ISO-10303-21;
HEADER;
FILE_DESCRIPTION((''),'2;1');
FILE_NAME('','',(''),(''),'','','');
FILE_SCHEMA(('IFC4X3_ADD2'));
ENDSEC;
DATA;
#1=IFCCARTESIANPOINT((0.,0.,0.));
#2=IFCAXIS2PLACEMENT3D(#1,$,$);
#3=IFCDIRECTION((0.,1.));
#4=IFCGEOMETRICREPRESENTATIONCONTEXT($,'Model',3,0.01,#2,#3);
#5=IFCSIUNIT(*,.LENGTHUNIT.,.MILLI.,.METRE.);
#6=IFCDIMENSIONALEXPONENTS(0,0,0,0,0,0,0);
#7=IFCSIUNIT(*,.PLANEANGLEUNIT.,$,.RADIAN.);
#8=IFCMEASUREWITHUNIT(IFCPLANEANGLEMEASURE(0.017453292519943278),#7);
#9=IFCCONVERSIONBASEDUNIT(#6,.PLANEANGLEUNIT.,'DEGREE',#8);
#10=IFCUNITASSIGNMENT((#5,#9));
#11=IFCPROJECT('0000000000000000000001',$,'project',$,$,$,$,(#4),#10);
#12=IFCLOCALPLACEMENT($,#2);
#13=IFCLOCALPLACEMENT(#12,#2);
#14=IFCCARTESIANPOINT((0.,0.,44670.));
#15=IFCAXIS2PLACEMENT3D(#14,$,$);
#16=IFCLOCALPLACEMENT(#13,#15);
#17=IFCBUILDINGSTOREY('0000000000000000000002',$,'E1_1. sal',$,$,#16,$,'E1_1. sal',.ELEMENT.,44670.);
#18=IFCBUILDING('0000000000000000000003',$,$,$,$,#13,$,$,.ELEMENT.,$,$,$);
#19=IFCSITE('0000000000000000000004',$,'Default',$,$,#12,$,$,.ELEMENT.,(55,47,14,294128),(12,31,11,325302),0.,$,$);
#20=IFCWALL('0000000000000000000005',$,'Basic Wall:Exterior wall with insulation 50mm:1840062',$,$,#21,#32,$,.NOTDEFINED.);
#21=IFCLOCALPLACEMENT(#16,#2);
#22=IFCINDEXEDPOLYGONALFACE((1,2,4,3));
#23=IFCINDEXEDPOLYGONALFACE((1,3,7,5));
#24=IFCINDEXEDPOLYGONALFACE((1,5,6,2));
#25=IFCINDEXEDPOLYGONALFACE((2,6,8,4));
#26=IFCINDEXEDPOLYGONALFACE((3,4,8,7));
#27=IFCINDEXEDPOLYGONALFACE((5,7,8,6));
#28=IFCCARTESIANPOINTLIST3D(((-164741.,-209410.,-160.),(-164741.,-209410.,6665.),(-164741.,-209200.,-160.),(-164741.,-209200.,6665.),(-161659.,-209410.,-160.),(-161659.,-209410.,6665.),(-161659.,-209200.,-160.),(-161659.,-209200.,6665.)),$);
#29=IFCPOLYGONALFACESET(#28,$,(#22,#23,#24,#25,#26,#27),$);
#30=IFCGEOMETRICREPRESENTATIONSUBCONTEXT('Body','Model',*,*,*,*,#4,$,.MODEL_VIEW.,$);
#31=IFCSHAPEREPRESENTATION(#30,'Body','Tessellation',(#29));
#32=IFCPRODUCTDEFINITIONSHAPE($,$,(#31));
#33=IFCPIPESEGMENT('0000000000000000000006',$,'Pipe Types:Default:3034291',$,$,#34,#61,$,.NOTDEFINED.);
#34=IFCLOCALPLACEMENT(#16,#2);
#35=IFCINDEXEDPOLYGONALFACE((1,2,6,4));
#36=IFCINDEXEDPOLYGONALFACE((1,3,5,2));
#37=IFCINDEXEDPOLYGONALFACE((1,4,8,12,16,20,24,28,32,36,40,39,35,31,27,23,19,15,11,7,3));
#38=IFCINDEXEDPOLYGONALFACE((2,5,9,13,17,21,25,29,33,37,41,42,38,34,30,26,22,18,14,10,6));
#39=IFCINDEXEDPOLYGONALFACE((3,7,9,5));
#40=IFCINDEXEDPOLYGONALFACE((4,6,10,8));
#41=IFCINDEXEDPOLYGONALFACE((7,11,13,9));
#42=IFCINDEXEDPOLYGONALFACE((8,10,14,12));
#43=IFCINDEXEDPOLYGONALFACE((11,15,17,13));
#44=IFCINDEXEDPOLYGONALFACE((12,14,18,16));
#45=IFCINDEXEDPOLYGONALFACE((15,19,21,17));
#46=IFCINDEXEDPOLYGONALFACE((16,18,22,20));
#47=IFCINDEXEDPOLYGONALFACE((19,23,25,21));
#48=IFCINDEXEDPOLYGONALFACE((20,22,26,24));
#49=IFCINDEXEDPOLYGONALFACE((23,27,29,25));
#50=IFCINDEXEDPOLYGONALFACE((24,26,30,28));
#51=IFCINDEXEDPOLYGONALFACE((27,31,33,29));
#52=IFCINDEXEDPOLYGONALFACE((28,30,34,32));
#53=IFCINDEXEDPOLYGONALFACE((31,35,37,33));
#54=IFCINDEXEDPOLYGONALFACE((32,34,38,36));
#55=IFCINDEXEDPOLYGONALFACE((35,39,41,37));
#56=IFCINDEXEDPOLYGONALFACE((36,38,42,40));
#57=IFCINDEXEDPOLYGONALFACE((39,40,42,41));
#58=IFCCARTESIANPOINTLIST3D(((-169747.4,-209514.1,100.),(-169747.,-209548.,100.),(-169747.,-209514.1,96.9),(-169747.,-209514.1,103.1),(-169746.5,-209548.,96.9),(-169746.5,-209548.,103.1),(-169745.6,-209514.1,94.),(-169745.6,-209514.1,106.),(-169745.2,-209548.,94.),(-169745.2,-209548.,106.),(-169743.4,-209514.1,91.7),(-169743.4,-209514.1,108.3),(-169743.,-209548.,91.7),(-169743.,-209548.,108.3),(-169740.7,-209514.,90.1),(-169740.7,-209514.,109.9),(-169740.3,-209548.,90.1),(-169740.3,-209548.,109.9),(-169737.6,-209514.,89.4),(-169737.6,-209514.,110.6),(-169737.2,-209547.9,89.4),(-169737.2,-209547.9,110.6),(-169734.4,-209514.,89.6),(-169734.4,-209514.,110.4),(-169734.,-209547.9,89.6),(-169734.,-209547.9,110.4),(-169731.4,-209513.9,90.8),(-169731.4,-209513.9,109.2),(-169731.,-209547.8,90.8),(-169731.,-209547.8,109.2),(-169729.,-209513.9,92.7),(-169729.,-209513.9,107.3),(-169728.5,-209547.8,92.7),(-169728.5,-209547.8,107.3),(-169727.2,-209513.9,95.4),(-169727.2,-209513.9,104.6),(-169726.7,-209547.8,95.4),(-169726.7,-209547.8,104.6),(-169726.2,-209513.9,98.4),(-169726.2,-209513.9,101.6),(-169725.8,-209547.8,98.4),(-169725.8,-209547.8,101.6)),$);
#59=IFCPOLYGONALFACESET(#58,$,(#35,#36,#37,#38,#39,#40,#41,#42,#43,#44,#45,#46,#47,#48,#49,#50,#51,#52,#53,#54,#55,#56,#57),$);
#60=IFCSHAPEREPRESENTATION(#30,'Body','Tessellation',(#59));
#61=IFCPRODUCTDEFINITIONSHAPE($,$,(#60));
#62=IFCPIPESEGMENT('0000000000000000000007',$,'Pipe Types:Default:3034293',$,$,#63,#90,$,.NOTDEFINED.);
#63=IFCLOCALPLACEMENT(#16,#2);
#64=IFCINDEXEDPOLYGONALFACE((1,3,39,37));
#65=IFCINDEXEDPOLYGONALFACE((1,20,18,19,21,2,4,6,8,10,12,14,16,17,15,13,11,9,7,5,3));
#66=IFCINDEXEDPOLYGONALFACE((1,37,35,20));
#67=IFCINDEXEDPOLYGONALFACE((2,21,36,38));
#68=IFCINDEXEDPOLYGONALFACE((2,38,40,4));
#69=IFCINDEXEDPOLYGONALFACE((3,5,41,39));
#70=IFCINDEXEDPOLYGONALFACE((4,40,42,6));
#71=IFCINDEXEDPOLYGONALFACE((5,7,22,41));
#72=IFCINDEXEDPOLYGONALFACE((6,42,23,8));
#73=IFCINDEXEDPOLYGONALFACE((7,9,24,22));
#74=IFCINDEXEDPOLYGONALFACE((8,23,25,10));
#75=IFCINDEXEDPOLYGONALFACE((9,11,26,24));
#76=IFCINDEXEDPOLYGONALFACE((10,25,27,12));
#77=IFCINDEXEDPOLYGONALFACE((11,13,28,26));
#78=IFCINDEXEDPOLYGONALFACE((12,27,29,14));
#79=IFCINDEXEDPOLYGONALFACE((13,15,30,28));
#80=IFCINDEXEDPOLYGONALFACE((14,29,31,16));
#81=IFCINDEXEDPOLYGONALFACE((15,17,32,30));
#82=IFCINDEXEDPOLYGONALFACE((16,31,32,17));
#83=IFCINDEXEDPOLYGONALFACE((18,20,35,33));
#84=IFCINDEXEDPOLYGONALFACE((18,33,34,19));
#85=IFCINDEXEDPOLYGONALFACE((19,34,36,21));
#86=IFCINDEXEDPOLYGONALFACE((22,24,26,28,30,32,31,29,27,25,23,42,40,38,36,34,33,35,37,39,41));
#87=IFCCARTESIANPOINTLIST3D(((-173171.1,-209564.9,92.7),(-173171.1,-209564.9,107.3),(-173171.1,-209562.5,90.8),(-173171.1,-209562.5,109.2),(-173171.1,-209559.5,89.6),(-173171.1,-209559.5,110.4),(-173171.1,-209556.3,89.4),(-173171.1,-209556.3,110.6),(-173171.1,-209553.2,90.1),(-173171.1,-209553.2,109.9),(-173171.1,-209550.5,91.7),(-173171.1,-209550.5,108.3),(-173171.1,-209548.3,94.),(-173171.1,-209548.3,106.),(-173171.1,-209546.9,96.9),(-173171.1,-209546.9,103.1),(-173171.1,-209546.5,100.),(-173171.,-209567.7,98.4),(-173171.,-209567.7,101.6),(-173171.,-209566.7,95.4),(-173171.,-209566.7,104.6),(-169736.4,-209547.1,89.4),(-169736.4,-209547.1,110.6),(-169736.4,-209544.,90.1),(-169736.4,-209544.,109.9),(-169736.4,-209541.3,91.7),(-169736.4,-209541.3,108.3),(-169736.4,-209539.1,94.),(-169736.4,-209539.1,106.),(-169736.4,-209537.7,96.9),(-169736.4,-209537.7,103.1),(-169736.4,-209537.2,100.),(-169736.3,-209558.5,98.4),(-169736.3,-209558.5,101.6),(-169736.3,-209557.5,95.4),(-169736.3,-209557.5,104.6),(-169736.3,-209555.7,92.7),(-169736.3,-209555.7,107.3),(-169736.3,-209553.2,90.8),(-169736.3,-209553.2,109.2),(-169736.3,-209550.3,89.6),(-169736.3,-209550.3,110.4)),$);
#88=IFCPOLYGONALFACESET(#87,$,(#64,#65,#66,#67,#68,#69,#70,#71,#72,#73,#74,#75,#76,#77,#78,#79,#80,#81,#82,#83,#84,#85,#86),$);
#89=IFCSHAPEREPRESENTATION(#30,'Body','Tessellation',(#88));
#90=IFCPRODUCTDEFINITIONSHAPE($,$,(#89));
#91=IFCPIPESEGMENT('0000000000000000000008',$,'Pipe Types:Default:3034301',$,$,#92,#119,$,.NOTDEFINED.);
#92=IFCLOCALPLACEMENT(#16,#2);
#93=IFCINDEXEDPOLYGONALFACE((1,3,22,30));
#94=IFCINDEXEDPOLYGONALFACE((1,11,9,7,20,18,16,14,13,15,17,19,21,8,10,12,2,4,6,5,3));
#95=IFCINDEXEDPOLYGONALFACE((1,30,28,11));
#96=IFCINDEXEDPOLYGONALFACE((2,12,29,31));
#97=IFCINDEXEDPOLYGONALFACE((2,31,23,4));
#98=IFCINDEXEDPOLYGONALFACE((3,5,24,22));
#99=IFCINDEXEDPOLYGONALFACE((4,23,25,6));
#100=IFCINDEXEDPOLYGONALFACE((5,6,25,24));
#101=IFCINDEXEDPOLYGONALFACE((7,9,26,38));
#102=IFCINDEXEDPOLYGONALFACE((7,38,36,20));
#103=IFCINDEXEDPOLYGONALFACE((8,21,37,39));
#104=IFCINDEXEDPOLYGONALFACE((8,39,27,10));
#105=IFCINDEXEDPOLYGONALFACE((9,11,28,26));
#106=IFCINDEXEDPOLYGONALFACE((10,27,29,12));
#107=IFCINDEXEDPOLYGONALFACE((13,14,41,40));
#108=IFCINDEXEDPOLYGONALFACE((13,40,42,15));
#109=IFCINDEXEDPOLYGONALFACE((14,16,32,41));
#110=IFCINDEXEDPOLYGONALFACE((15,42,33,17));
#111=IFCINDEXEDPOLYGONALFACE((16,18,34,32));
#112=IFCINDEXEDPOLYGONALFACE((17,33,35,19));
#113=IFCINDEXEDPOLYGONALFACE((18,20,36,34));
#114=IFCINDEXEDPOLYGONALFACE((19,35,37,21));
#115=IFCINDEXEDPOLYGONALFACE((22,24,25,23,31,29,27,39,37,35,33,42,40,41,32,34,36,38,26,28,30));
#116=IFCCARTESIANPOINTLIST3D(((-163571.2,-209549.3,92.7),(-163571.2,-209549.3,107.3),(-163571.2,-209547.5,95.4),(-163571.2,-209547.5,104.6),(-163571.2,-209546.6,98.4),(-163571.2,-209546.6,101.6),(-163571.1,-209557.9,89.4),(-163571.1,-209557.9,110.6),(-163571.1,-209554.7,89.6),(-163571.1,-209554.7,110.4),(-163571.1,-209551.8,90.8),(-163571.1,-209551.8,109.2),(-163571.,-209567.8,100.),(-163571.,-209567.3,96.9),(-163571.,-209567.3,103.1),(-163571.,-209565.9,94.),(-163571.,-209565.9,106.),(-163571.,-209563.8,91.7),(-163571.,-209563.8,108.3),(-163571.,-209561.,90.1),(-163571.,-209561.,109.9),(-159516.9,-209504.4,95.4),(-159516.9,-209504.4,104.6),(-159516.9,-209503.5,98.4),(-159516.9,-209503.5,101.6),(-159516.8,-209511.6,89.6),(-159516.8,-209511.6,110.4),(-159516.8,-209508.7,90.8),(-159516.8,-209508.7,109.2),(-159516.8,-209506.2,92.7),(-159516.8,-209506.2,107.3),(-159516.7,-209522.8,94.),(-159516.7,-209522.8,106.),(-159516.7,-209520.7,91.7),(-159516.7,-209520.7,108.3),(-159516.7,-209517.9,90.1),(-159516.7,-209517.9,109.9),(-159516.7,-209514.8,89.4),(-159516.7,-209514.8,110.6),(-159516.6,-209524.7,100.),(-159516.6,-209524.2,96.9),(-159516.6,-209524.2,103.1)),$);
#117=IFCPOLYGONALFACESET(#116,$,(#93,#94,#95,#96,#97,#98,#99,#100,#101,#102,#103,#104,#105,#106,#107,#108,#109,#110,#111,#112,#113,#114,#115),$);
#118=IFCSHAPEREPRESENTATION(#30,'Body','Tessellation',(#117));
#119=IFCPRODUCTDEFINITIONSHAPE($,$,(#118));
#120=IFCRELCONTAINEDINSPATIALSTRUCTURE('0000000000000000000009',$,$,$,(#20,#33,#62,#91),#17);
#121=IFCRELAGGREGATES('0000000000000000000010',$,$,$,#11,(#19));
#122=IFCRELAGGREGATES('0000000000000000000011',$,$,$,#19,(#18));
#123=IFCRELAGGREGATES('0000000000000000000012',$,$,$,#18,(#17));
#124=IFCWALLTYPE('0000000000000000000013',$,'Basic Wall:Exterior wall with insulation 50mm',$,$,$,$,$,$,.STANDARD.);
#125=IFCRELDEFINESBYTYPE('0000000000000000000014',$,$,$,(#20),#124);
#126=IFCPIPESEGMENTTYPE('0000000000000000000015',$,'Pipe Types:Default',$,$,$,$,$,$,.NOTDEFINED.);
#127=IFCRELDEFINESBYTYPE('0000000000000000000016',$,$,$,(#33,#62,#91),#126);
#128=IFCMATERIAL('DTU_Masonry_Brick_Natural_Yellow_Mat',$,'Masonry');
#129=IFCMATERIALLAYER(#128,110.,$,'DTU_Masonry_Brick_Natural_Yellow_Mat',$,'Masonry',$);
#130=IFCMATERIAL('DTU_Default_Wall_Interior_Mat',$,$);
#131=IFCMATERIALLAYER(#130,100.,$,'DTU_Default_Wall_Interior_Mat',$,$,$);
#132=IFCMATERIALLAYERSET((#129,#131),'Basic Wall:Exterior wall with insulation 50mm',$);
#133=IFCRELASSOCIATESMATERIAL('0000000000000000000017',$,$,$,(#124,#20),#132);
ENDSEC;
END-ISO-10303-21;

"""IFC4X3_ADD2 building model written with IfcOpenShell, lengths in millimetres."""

from ifc_helpers import new_model, entity, si_unit, converted_unit, direction, frame, frame_2d, origin, origin_2d_with_axis, place, context, subcontext, project, spatial, rectangle, circle, extrude, material, layer, layer_set, type_object, element, save


model = new_model("IFC4X3_ADD2")

# Units and contexts
model_context = context("Model", 3, precision=0.01, world=origin(), true_north=direction((0.0, 1.0)))
body_context = subcontext(model_context, "Body", "Model", "MODEL_VIEW")
ifc_project = project(units=[si_unit("LENGTHUNIT", "METRE", prefix="MILLI"), converted_unit("PLANEANGLEUNIT", "DEGREE", entity("IfcPlaneAngleMeasure", 0.017453292519943278), si_unit("PLANEANGLEUNIT", "RADIAN"), dimensions=[0, 0, 0, 0, 0, 0, 0])], contexts=[model_context])

# Site, building, storey
site_placement = place(None, origin())
site = spatial("IfcSite", under=ifc_project, at=site_placement, Name="Default", CompositionType="ELEMENT", RefLatitude=(55, 47, 14, 294128), RefLongitude=(12, 31, 11, 325302), RefElevation=0.0)
building_placement = place(site_placement, origin())
building = spatial("IfcBuilding", under=site, at=building_placement, CompositionType="ELEMENT")
storey_placement = place(building_placement, frame((0.0, 0.0, 44670.0)))
storey = spatial("IfcBuildingStorey", under=building, at=storey_placement, Name="E1_1. sal", LongName="E1_1. sal", CompositionType="ELEMENT", Elevation=44670.0)

# Wall
ifc_material_1 = material(Name="DTU_Masonry_Brick_Natural_Yellow_Mat", Category="Masonry")
ifc_layer_1 = layer(ifc_material_1, 110.0, Name="DTU_Masonry_Brick_Natural_Yellow_Mat", Category="Masonry")
ifc_material_2 = material(Name="DTU_Default_Wall_Interior_Mat")
ifc_layer_2 = layer(ifc_material_2, 100.0, Name="DTU_Default_Wall_Interior_Mat")
ifc_layer_set = layer_set([ifc_layer_1, ifc_layer_2], Name="Basic Wall:Exterior wall with insulation 50mm")
wall_type = type_object("IfcWallType", Name="Basic Wall:Exterior wall with insulation 50mm", PredefinedType="STANDARD", material=ifc_layer_set)
wall_placement = place(storey_placement, frame((-164741.0, -209305.0, -160.0)))
element("IfcWall", 1, at=wall_placement, inside=storey, type_object=wall_type, material=ifc_layer_set, Name="Basic Wall:Exterior wall with insulation 50mm:1840062", PredefinedType="NOTDEFINED", context=body_context, shape_type="SweptSolid", body=[
    extrude(rectangle(XDim=3082.0, YDim=210.0, at=frame_2d((1541.0, 0.0), x_axis=(-1.0, 0.0))), origin(), (0.0, 0.0, 1.0), 6825.0),
])

# Pipe segments
pipe_segment_type = type_object("IfcPipeSegmentType", Name="Pipe Types:Default", PredefinedType="NOTDEFINED")
pipe_segment_1_placement = place(storey_placement, frame((-169749.0, -209548.0, 87.7)))
element("IfcPipeSegment", 2, at=pipe_segment_1_placement, inside=storey, type_object=pipe_segment_type, Name="Pipe Types:Default:3034291", PredefinedType="NOTDEFINED", context=body_context, shape_type="SweptSolid", body=[
    extrude(circle(Radius=10.7, at=frame_2d((0.0, 0.0), x_axis=(1.0, 0.0))), frame((12.7, 0.1, 12.3), z_axis=(-0.012555, 0.999921, 0.0), x_axis=(-0.999921, -0.012555, 0.0)), (0.0, 0.0, 1.0), 33.9),
])
pipe_segment_2_placement = place(storey_placement, frame((-173171.1, -209569.4, 87.7)))
element("IfcPipeSegment", 3, at=pipe_segment_2_placement, inside=storey, type_object=pipe_segment_type, Name="Pipe Types:Default:3034293", PredefinedType="NOTDEFINED", context=body_context, shape_type="SweptSolid", body=[
    extrude(circle(Radius=10.7, at=frame_2d((0.0, 0.0), x_axis=(1.0, 0.0))), frame((0.0, 12.3, 12.3), z_axis=(0.999996, 0.002683, 0.0), x_axis=(-0.002683, 0.999996, 0.0)), (0.0, 0.0, 1.0), 3434.7),
])
pipe_segment_3_placement = place(storey_placement, frame((-163571.2, -209569.4, 87.7)))
element("IfcPipeSegment", 4, at=pipe_segment_3_placement, inside=storey, type_object=pipe_segment_type, Name="Pipe Types:Default:3034301", PredefinedType="NOTDEFINED", context=body_context, shape_type="SweptSolid", body=[
    extrude(circle(Radius=10.7, at=origin_2d_with_axis()), frame((0.1, 12.3, 12.3), z_axis=(0.999943, 0.010635, 0.0), x_axis=(0.010635, -0.999943, 0.0)), (0.0, 0.0, 1.0), 4054.5),
])

save(model, "model.ifc")
